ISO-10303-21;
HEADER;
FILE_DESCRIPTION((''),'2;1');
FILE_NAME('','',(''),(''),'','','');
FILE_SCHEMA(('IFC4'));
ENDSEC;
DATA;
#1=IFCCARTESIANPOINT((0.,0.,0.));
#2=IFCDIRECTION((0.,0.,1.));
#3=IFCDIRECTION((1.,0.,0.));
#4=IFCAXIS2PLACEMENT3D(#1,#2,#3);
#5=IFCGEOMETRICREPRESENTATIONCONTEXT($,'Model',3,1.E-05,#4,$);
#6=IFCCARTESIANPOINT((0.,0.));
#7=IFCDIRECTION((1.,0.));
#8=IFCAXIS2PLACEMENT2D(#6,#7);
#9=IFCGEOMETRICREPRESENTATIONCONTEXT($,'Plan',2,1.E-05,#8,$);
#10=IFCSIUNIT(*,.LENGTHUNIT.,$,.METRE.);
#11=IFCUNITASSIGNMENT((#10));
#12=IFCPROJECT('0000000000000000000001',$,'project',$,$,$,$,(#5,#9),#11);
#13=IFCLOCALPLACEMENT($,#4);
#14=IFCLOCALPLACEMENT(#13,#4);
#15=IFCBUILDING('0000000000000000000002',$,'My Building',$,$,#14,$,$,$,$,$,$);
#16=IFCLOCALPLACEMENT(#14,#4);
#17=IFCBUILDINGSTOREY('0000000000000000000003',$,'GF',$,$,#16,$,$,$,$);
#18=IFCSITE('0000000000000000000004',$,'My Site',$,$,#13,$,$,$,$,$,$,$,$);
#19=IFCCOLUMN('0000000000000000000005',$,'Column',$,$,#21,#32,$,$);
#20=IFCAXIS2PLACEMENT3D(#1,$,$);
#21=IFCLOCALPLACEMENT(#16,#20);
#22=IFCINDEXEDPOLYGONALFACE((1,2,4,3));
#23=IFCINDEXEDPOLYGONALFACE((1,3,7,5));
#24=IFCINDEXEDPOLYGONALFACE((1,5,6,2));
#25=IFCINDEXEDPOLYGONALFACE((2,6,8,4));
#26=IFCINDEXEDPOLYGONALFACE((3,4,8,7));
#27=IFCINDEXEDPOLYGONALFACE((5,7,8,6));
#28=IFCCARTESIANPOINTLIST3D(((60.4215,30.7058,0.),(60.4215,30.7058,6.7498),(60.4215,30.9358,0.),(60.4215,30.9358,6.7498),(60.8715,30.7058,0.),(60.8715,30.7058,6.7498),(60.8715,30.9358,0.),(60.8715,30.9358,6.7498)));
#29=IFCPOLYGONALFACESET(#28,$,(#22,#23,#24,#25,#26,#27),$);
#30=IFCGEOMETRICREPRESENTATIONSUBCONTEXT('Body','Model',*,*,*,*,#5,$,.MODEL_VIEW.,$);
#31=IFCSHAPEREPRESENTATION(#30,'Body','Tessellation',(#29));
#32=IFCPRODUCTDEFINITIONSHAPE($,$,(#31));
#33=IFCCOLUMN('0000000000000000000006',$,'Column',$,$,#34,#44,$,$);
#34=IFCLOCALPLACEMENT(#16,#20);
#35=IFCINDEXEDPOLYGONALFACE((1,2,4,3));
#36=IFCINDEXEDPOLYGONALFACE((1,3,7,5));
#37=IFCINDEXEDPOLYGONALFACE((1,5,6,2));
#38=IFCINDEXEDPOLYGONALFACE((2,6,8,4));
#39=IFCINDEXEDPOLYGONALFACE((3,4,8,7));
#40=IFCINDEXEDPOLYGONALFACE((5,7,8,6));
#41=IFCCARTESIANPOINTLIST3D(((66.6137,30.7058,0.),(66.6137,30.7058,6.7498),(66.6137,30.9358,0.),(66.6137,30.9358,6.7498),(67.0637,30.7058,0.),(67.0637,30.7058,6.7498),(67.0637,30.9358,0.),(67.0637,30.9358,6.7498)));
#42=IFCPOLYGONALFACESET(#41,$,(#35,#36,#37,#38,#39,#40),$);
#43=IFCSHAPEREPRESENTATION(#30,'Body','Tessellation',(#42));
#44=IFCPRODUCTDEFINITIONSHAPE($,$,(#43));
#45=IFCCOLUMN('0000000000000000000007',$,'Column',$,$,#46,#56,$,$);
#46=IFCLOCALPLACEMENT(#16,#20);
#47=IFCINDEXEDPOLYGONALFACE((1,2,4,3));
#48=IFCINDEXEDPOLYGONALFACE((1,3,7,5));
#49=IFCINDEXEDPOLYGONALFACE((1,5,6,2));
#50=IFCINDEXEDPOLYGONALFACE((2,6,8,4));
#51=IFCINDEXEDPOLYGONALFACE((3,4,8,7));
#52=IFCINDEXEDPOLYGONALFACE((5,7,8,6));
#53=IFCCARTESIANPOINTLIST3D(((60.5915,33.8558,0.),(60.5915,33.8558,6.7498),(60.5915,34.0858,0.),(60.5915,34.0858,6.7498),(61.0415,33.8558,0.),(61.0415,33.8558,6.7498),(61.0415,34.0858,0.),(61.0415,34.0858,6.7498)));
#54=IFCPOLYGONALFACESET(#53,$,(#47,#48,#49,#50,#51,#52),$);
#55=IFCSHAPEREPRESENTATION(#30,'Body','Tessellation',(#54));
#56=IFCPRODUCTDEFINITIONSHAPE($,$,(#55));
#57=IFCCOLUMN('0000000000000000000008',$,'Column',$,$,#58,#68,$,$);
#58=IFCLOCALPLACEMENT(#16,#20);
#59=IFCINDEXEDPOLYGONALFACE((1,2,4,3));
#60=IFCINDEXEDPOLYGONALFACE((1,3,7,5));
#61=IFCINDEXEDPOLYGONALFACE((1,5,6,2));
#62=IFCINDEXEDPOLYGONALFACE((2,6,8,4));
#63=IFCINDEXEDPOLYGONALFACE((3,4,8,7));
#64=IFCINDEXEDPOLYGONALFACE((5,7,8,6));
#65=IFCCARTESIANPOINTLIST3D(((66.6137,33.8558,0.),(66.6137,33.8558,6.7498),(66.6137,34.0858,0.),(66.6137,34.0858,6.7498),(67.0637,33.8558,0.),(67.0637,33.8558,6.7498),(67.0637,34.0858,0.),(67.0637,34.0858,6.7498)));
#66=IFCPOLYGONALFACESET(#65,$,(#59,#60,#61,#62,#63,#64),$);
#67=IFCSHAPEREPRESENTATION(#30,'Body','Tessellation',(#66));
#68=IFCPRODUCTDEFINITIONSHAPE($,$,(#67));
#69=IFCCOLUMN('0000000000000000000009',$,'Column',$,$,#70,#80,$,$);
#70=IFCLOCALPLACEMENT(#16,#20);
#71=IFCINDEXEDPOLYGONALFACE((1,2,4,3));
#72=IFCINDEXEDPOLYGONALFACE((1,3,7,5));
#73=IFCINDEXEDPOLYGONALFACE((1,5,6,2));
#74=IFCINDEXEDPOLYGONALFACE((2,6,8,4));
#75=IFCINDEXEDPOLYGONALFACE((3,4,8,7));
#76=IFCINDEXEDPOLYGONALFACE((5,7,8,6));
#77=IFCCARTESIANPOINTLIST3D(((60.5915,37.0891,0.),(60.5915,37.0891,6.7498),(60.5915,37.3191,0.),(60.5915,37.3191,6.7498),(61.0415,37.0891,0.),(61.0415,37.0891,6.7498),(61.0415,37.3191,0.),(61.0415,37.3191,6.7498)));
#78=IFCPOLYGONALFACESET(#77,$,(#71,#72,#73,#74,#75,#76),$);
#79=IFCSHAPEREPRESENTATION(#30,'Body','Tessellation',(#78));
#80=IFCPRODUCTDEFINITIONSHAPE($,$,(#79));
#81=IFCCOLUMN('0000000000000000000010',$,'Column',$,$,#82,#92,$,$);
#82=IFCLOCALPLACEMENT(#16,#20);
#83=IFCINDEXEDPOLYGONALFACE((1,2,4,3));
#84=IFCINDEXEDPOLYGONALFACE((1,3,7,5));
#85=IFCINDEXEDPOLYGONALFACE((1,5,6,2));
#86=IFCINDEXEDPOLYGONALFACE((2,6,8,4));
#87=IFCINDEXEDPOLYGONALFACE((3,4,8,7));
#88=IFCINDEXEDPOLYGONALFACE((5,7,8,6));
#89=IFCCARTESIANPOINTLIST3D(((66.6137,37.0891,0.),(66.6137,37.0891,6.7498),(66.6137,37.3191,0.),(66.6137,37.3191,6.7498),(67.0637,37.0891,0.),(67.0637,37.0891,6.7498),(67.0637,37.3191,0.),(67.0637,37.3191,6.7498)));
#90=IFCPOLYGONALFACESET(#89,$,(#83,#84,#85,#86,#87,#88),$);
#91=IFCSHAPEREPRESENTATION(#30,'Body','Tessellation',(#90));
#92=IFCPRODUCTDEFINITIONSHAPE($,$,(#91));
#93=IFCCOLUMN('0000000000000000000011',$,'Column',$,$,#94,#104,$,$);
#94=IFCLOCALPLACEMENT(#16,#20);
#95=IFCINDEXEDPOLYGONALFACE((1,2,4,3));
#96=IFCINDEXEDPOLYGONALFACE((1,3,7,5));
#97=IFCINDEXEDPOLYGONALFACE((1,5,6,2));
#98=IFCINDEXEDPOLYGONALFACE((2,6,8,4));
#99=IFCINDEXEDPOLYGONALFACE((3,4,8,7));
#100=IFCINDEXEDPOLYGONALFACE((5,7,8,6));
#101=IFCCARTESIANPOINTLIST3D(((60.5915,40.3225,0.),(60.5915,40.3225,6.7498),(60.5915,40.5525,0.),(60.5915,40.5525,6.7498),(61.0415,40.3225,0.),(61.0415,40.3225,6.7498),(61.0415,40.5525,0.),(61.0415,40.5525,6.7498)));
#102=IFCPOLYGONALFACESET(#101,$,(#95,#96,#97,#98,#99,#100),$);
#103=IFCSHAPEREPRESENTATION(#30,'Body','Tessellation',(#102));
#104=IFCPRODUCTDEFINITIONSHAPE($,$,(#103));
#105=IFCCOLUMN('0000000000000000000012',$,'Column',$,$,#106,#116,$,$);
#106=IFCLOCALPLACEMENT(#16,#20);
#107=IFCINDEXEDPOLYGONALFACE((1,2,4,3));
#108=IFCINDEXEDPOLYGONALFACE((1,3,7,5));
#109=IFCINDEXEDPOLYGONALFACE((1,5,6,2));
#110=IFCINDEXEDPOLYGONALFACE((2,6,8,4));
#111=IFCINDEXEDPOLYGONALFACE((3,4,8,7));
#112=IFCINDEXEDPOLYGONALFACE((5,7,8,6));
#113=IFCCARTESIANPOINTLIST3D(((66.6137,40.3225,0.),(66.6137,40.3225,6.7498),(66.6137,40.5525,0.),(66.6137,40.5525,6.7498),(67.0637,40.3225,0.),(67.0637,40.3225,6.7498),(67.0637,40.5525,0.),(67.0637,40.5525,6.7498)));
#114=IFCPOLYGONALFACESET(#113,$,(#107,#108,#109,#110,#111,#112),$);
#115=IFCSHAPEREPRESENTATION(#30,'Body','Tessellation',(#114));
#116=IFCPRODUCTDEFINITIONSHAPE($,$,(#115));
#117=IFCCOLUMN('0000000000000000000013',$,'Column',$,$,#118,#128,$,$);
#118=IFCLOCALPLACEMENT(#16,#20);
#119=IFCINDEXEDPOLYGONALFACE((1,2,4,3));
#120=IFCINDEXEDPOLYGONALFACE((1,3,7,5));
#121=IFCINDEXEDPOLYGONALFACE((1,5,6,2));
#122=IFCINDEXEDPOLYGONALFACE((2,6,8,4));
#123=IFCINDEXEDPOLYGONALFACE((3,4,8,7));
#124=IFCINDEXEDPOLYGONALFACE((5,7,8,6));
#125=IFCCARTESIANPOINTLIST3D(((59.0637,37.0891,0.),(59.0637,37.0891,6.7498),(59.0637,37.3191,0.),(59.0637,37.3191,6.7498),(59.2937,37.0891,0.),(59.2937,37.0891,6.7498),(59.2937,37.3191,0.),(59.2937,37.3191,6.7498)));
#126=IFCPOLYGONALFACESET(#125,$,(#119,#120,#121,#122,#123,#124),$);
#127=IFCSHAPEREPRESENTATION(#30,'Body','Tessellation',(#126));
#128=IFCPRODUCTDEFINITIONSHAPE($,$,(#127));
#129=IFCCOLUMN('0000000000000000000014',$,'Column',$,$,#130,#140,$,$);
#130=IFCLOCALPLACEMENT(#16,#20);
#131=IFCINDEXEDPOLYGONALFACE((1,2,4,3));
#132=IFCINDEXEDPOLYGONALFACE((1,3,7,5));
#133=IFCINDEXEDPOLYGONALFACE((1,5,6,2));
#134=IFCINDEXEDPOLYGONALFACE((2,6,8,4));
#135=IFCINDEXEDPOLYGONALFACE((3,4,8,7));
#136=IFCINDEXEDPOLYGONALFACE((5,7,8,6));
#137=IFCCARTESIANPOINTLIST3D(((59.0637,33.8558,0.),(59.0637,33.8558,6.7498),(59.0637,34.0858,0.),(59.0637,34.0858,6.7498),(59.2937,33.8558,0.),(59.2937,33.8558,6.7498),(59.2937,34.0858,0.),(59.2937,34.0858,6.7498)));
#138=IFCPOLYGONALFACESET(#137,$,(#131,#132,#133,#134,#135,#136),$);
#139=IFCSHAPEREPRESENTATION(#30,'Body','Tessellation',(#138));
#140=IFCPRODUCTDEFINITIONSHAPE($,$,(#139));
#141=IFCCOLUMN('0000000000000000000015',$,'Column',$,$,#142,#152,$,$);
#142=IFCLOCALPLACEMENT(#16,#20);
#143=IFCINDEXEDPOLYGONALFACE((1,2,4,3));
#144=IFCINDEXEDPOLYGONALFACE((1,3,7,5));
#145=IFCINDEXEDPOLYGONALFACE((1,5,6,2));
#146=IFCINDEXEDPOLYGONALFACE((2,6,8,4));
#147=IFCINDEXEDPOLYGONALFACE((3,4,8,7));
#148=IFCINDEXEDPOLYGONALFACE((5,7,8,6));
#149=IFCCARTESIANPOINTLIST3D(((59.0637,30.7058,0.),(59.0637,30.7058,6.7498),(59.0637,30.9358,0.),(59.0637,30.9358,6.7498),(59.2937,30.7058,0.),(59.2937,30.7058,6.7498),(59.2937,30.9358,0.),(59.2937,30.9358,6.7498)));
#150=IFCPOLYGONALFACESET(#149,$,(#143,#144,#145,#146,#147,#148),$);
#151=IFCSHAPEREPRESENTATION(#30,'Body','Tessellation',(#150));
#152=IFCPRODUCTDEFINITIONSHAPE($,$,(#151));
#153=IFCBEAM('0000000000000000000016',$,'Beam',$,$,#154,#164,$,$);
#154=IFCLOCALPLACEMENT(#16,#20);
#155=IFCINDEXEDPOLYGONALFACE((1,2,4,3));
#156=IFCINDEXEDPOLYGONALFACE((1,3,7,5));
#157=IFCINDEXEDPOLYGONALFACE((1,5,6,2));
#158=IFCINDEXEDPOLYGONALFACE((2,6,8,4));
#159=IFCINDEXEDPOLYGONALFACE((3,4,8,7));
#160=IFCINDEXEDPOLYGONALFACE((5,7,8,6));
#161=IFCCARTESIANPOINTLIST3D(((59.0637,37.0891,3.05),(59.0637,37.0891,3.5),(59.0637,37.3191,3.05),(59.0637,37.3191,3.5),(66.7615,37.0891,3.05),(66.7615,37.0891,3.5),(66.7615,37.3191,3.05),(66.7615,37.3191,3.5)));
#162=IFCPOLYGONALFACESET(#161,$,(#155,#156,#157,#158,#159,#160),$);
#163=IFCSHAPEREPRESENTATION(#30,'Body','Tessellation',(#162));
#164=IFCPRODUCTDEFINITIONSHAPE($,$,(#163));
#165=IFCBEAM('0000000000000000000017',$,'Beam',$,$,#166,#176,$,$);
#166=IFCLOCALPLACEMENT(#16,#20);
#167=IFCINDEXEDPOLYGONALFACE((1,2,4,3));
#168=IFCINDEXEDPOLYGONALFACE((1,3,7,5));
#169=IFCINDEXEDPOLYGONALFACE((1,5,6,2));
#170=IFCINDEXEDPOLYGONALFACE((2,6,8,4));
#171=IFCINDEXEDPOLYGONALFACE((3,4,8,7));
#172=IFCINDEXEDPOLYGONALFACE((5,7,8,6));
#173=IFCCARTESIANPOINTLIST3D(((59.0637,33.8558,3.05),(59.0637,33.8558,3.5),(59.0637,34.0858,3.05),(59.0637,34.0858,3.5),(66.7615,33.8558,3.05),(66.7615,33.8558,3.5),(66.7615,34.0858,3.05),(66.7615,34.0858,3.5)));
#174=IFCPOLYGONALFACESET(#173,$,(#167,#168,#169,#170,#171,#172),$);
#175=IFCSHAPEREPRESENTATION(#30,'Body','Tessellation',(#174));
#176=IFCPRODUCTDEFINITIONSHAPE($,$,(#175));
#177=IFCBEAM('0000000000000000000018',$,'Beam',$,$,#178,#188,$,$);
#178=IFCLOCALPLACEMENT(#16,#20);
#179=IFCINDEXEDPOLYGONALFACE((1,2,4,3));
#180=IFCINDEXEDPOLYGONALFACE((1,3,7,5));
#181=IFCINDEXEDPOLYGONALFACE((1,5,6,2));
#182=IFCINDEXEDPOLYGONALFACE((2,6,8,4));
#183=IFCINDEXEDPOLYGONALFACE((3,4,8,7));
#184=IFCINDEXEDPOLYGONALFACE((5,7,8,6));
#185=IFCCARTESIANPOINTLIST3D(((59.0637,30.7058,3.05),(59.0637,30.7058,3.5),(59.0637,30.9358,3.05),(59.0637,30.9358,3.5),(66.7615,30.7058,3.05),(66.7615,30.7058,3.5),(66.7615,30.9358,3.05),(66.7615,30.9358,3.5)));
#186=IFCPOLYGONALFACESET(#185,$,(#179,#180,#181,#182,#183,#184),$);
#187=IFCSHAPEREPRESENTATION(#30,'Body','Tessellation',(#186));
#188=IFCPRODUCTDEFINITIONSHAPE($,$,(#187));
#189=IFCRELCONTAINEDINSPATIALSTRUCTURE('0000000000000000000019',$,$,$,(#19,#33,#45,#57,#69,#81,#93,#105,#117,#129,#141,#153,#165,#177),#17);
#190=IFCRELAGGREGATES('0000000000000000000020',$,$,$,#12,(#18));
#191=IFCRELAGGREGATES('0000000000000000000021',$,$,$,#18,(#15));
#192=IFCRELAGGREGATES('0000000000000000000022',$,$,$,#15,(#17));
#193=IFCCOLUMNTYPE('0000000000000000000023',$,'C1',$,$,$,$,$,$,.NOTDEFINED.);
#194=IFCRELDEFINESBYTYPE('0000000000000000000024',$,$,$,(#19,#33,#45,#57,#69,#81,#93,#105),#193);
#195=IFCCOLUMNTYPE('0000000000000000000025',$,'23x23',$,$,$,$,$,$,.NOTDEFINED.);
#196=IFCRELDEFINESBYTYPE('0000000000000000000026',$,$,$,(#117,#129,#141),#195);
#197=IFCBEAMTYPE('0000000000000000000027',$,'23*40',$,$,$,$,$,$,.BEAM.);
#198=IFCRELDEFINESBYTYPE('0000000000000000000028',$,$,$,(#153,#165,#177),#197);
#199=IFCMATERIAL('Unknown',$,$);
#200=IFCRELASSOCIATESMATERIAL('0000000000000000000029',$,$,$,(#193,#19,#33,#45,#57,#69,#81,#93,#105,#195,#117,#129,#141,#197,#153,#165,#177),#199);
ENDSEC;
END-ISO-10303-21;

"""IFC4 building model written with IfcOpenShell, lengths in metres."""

from ifc_helpers import new_model, si_unit, frame, origin_with_axes, origin_2d_with_axis, place, context, subcontext, project, spatial, rectangle, extrude, material, material_profile, profile_set, profile_usage, type_object, element, save


model = new_model("IFC4")

# Units and contexts
model_context = context("Model", 3, precision=1e-05, world=origin_with_axes())
plan_context = context("Plan", 2, precision=1e-05, world=origin_2d_with_axis())
body_context = subcontext(model_context, "Body", "Model", "MODEL_VIEW")
ifc_project = project(units=[si_unit("LENGTHUNIT", "METRE")], contexts=[model_context, plan_context])

# Site, building, storey
site_placement = place(None, origin_with_axes())
site = spatial("IfcSite", under=ifc_project, at=site_placement, Name="My Site")
building_placement = place(site_placement, origin_with_axes())
building = spatial("IfcBuilding", under=site, at=building_placement, Name="My Building")
storey_placement = place(building_placement, origin_with_axes())
storey = spatial("IfcBuildingStorey", under=building, at=storey_placement, Name="GF")

# Columns
ifc_material = material(Name="Unknown")
ifc_material_profile_1 = material_profile(ifc_material, rectangle(XDim=0.45, YDim=0.23))
ifc_profile_set_1 = profile_set([ifc_material_profile_1])
ifc_profile_usage_1 = profile_usage(ifc_profile_set_1, cardinal=5)
column_type_1 = type_object("IfcColumnType", Name="C1", PredefinedType="NOTDEFINED", material=ifc_profile_set_1)
column_1_placement = place(storey_placement, frame((60.6465, 30.8208, 0.0), z_axis=(0.0, 0.0, 1.0), x_axis=(1.0, 0.0, 0.0)))
element("IfcColumn", 1, at=column_1_placement, inside=storey, type_object=column_type_1, material=ifc_profile_usage_1, Name="Column", context=body_context, shape_type="SweptSolid", body=[
    extrude(rectangle(XDim=0.45, YDim=0.23), origin_with_axes(), (0.0, 0.0, 1.0), 6.7498),
])
ifc_profile_usage_2 = profile_usage(ifc_profile_set_1, cardinal=5)
column_2_placement = place(storey_placement, frame((66.8387, 30.8208, 0.0), z_axis=(0.0, 0.0, 1.0), x_axis=(1.0, 0.0, 0.0)))
element("IfcColumn", 2, at=column_2_placement, inside=storey, type_object=column_type_1, material=ifc_profile_usage_2, Name="Column", context=body_context, shape_type="SweptSolid", body=[
    extrude(rectangle(XDim=0.45, YDim=0.23), origin_with_axes(), (0.0, 0.0, 1.0), 6.7498),
])
ifc_profile_usage_3 = profile_usage(ifc_profile_set_1, cardinal=5)
column_3_placement = place(storey_placement, frame((60.8165, 33.9708, 0.0), z_axis=(0.0, 0.0, 1.0), x_axis=(1.0, 0.0, 0.0)))
element("IfcColumn", 3, at=column_3_placement, inside=storey, type_object=column_type_1, material=ifc_profile_usage_3, Name="Column", context=body_context, shape_type="SweptSolid", body=[
    extrude(rectangle(XDim=0.45, YDim=0.23), origin_with_axes(), (0.0, 0.0, 1.0), 6.7498),
])
ifc_profile_usage_4 = profile_usage(ifc_profile_set_1, cardinal=5)
column_4_placement = place(storey_placement, frame((66.8387, 33.9708, 0.0), z_axis=(0.0, 0.0, 1.0), x_axis=(1.0, 0.0, 0.0)))
element("IfcColumn", 4, at=column_4_placement, inside=storey, type_object=column_type_1, material=ifc_profile_usage_4, Name="Column", context=body_context, shape_type="SweptSolid", body=[
    extrude(rectangle(XDim=0.45, YDim=0.23), origin_with_axes(), (0.0, 0.0, 1.0), 6.7498),
])
ifc_profile_usage_5 = profile_usage(ifc_profile_set_1, cardinal=5)
column_5_placement = place(storey_placement, frame((60.8165, 37.2041, 0.0), z_axis=(0.0, 0.0, 1.0), x_axis=(1.0, 0.0, 0.0)))
element("IfcColumn", 5, at=column_5_placement, inside=storey, type_object=column_type_1, material=ifc_profile_usage_5, Name="Column", context=body_context, shape_type="SweptSolid", body=[
    extrude(rectangle(XDim=0.45, YDim=0.23), origin_with_axes(), (0.0, 0.0, 1.0), 6.7498),
])
ifc_profile_usage_6 = profile_usage(ifc_profile_set_1, cardinal=5)
column_6_placement = place(storey_placement, frame((66.8387, 37.2041, 0.0), z_axis=(0.0, 0.0, 1.0), x_axis=(1.0, 0.0, 0.0)))
element("IfcColumn", 6, at=column_6_placement, inside=storey, type_object=column_type_1, material=ifc_profile_usage_6, Name="Column", context=body_context, shape_type="SweptSolid", body=[
    extrude(rectangle(XDim=0.45, YDim=0.23), origin_with_axes(), (0.0, 0.0, 1.0), 6.7498),
])
ifc_profile_usage_7 = profile_usage(ifc_profile_set_1, cardinal=5)
column_7_placement = place(storey_placement, frame((60.8165, 40.4375, 0.0), z_axis=(0.0, 0.0, 1.0), x_axis=(1.0, 0.0, 0.0)))
element("IfcColumn", 7, at=column_7_placement, inside=storey, type_object=column_type_1, material=ifc_profile_usage_7, Name="Column", context=body_context, shape_type="SweptSolid", body=[
    extrude(rectangle(XDim=0.45, YDim=0.23), origin_with_axes(), (0.0, 0.0, 1.0), 6.7498),
])
ifc_profile_usage_8 = profile_usage(ifc_profile_set_1, cardinal=5)
column_8_placement = place(storey_placement, frame((66.8387, 40.4375, 0.0), z_axis=(0.0, 0.0, 1.0), x_axis=(1.0, 0.0, 0.0)))
element("IfcColumn", 8, at=column_8_placement, inside=storey, type_object=column_type_1, material=ifc_profile_usage_8, Name="Column", context=body_context, shape_type="SweptSolid", body=[
    extrude(rectangle(XDim=0.45, YDim=0.23), origin_with_axes(), (0.0, 0.0, 1.0), 6.7498),
])
ifc_material_profile_2 = material_profile(ifc_material, rectangle(XDim=0.23, YDim=0.23))
ifc_profile_set_2 = profile_set([ifc_material_profile_2])
ifc_profile_usage_9 = profile_usage(ifc_profile_set_2, cardinal=5)
column_type_2 = type_object("IfcColumnType", Name="23x23", PredefinedType="NOTDEFINED", material=ifc_profile_set_2)
column_9_placement = place(storey_placement, frame((59.1787, 37.2041, 0.0), z_axis=(0.0, 0.0, 1.0), x_axis=(1.0, 0.0, 0.0)))
element("IfcColumn", 9, at=column_9_placement, inside=storey, type_object=column_type_2, material=ifc_profile_usage_9, Name="Column", context=body_context, shape_type="SweptSolid", body=[
    extrude(rectangle(XDim=0.23, YDim=0.23), origin_with_axes(), (0.0, 0.0, 1.0), 6.7498),
])
ifc_profile_usage_10 = profile_usage(ifc_profile_set_2, cardinal=5)
column_10_placement = place(storey_placement, frame((59.1787, 33.9708, 0.0), z_axis=(0.0, 0.0, 1.0), x_axis=(1.0, 0.0, 0.0)))
element("IfcColumn", 10, at=column_10_placement, inside=storey, type_object=column_type_2, material=ifc_profile_usage_10, Name="Column", context=body_context, shape_type="SweptSolid", body=[
    extrude(rectangle(XDim=0.23, YDim=0.23), origin_with_axes(), (0.0, 0.0, 1.0), 6.7498),
])
ifc_profile_usage_11 = profile_usage(ifc_profile_set_2, cardinal=5)
column_11_placement = place(storey_placement, frame((59.1787, 30.8208, 0.0), z_axis=(0.0, 0.0, 1.0), x_axis=(1.0, 0.0, 0.0)))
element("IfcColumn", 11, at=column_11_placement, inside=storey, type_object=column_type_2, material=ifc_profile_usage_11, Name="Column", context=body_context, shape_type="SweptSolid", body=[
    extrude(rectangle(XDim=0.23, YDim=0.23), origin_with_axes(), (0.0, 0.0, 1.0), 6.7498),
])

# Beams
ifc_material_profile_3 = material_profile(ifc_material, rectangle(XDim=0.23, YDim=0.45))
ifc_profile_set_3 = profile_set([ifc_material_profile_3])
ifc_profile_usage_12 = profile_usage(ifc_profile_set_3, cardinal=5)
beam_type = type_object("IfcBeamType", Name="23*40", PredefinedType="BEAM", material=ifc_profile_set_3)
beam_1_placement = place(storey_placement, frame((59.0637, 37.2041, 3.275), z_axis=(1.0, 0.0, 0.0), x_axis=(0.0, 1.0, 0.0)))
element("IfcBeam", 12, at=beam_1_placement, inside=storey, type_object=beam_type, material=ifc_profile_usage_12, Name="Beam", context=body_context, shape_type="SweptSolid", body=[
    extrude(rectangle(XDim=0.23, YDim=0.45), origin_with_axes(), (0.0, 0.0, 1.0), 7.6978),
])
ifc_profile_usage_13 = profile_usage(ifc_profile_set_3, cardinal=5)
beam_2_placement = place(storey_placement, frame((59.0637, 33.9708, 3.275), z_axis=(1.0, 0.0, 0.0), x_axis=(0.0, 1.0, 0.0)))
element("IfcBeam", 13, at=beam_2_placement, inside=storey, type_object=beam_type, material=ifc_profile_usage_13, Name="Beam", context=body_context, shape_type="SweptSolid", body=[
    extrude(rectangle(XDim=0.23, YDim=0.45), origin_with_axes(), (0.0, 0.0, 1.0), 7.6978),
])
ifc_profile_usage_14 = profile_usage(ifc_profile_set_3, cardinal=5)
beam_3_placement = place(storey_placement, frame((59.0637, 30.8208, 3.275), z_axis=(1.0, 0.0, 0.0), x_axis=(0.0, 1.0, 0.0)))
element("IfcBeam", 14, at=beam_3_placement, inside=storey, type_object=beam_type, material=ifc_profile_usage_14, Name="Beam", context=body_context, shape_type="SweptSolid", body=[
    extrude(rectangle(XDim=0.23, YDim=0.45), origin_with_axes(), (0.0, 0.0, 1.0), 7.6978),
])

save(model, "model.ifc")
